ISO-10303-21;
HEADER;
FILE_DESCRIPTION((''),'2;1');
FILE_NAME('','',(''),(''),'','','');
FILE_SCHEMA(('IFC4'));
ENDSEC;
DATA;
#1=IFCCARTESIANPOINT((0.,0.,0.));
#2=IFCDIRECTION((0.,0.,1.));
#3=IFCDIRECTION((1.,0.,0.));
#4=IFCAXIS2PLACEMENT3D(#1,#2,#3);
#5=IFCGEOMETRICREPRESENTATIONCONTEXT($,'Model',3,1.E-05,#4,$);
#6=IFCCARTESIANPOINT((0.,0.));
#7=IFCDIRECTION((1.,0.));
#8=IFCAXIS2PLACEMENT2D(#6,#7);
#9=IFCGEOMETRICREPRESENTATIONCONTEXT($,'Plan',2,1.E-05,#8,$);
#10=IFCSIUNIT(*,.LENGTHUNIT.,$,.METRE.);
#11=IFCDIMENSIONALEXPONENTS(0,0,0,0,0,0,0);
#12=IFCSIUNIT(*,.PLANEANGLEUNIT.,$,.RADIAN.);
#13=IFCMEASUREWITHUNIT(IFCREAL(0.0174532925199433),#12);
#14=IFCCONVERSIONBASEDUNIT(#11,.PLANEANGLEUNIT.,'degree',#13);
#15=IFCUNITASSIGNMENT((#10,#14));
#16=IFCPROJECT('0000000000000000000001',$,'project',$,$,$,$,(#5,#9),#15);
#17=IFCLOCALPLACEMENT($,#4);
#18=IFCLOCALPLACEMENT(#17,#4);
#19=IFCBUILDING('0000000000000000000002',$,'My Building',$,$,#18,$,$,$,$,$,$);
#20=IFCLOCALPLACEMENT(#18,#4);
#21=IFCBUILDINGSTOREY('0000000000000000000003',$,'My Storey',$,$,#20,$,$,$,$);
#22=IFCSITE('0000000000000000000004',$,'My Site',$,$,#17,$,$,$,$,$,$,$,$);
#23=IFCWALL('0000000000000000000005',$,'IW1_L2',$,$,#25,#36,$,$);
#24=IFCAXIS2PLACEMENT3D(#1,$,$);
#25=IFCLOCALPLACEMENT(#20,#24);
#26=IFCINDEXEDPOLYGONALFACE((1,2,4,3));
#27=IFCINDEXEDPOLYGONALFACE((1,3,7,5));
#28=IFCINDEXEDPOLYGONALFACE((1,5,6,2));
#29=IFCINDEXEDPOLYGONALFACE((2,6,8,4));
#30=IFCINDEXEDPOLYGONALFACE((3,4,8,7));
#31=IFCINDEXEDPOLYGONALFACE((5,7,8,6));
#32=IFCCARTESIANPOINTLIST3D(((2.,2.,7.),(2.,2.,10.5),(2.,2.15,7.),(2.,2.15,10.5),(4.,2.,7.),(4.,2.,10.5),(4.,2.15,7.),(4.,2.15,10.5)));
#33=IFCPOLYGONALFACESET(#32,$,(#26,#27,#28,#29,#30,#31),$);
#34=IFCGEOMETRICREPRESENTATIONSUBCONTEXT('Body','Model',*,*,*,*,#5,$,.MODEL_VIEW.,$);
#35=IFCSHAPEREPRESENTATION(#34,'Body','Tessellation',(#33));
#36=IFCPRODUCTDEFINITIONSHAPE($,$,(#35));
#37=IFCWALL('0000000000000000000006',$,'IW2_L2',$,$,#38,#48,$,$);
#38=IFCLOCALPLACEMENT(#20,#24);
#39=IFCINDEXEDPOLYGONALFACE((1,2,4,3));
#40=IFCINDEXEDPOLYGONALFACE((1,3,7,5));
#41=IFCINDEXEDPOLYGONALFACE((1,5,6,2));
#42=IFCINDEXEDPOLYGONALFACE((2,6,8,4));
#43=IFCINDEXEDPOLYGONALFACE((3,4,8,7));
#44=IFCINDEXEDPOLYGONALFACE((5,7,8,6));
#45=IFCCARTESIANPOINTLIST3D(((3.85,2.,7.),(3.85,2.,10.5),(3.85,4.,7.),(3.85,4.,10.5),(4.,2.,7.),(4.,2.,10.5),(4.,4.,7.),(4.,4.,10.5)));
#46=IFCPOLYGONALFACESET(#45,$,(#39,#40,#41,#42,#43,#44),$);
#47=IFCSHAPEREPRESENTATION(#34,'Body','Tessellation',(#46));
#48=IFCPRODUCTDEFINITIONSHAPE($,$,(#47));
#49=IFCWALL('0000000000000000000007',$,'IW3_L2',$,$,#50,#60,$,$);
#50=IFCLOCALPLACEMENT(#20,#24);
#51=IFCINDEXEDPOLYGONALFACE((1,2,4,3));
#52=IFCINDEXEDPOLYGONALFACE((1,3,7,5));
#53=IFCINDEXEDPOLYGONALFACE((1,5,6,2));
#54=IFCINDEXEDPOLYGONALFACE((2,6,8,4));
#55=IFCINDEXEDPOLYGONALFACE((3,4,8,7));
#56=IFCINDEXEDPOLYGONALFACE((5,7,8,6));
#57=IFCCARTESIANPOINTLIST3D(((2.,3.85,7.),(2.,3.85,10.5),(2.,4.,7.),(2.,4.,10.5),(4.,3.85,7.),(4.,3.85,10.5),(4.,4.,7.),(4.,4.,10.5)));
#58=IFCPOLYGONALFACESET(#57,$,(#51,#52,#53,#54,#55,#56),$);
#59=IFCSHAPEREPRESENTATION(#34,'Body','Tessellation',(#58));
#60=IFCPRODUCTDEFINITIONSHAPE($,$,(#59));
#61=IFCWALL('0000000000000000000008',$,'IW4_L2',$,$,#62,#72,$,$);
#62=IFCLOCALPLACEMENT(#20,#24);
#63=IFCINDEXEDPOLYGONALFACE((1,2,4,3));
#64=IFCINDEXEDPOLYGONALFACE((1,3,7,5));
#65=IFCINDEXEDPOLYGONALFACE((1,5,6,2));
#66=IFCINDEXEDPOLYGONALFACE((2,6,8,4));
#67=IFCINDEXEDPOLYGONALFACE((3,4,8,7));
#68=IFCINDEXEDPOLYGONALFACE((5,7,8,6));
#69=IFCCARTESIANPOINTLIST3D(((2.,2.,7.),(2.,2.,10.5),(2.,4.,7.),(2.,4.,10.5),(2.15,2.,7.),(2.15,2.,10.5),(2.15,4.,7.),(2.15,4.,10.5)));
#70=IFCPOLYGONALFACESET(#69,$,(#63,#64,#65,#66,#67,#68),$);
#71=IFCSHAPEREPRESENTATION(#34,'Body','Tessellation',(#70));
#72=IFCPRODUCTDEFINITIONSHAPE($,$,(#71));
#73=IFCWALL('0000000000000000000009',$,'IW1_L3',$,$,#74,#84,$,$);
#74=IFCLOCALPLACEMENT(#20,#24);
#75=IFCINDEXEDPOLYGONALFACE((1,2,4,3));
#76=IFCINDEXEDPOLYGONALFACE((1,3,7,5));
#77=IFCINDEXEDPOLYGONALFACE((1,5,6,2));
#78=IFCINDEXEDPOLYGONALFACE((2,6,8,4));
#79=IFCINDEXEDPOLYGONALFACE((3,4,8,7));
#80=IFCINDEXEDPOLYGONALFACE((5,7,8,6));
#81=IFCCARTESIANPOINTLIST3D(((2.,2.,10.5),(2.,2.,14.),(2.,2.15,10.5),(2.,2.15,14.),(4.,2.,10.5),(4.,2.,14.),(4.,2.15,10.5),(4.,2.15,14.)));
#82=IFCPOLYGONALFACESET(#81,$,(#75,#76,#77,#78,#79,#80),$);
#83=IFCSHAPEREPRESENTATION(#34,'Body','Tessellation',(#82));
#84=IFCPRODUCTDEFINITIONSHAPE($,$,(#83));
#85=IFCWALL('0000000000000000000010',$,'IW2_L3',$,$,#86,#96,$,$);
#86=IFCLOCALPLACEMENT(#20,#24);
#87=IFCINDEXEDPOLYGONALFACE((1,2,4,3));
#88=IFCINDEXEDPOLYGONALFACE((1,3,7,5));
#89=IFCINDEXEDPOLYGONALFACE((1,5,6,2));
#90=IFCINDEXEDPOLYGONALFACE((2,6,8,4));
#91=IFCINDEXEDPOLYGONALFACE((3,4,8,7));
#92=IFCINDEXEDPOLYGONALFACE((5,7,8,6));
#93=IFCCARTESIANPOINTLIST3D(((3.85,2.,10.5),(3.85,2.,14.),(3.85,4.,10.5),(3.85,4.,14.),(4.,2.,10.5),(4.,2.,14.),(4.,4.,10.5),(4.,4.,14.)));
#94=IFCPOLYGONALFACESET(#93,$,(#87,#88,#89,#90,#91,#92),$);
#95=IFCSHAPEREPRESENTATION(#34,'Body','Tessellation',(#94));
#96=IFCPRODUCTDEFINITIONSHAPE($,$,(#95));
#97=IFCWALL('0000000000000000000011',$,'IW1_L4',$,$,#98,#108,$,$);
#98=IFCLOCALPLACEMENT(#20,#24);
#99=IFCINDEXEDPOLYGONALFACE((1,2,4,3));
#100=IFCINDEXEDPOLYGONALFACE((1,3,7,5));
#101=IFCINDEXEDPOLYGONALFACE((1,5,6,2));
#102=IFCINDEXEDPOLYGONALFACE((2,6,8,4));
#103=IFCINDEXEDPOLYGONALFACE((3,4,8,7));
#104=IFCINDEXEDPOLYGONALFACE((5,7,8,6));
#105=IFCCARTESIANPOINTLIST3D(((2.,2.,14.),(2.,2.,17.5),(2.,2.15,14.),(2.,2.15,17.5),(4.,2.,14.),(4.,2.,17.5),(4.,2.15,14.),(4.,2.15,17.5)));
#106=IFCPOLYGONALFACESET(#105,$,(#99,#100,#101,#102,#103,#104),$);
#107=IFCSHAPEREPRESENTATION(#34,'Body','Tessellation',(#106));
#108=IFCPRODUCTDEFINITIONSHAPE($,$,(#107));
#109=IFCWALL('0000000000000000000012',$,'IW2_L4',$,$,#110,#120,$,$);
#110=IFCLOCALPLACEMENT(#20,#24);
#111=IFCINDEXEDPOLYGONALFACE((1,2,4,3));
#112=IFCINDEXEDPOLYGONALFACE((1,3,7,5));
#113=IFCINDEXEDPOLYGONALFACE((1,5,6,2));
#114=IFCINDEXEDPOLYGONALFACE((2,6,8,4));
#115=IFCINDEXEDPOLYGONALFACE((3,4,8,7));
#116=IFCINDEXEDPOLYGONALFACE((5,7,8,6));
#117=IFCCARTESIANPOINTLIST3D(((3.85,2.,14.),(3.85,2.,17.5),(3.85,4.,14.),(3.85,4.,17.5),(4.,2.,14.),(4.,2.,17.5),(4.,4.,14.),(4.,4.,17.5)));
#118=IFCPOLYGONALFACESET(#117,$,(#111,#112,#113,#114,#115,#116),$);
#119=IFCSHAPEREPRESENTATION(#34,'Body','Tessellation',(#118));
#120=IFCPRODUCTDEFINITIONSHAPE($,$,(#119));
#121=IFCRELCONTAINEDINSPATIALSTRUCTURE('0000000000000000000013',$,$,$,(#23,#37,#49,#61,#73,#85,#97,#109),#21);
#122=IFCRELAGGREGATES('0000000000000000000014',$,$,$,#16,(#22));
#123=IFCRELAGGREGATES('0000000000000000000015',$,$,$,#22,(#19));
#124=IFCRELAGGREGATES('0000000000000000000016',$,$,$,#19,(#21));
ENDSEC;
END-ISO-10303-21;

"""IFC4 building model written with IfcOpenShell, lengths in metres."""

from ifc_helpers import new_model, entity, si_unit, converted_unit, frame, origin_with_axes, origin_2d_with_axis, place, context, subcontext, project, spatial, indexed_curve, outline, extrude, element, save


model = new_model("IFC4")

# Units and contexts
model_context = context("Model", 3, precision=1e-05, world=origin_with_axes())
plan_context = context("Plan", 2, precision=1e-05, world=origin_2d_with_axis())
body_context = subcontext(model_context, "Body", "Model", "MODEL_VIEW")
ifc_project = project(units=[si_unit("LENGTHUNIT", "METRE"), converted_unit("PLANEANGLEUNIT", "degree", entity("IfcReal", 0.0174532925199433), si_unit("PLANEANGLEUNIT", "RADIAN"), dimensions=[0, 0, 0, 0, 0, 0, 0])], contexts=[model_context, plan_context])

# Site, building, storey
site_placement = place(None, origin_with_axes())
site = spatial("IfcSite", under=ifc_project, at=site_placement, Name="My Site")
building_placement = place(site_placement, origin_with_axes())
building = spatial("IfcBuilding", under=site, at=building_placement, Name="My Building")
storey_placement = place(building_placement, origin_with_axes())
storey = spatial("IfcBuildingStorey", under=building, at=storey_placement, Name="My Storey")

# Walls
for number, where, z_axis, x_axis, name in (
    (1, (2.0, 2.0, 7.0), (0.0, 0.0, 1.0), (1.0, 0.0, 0.0), "IW1_L2"),
    (2, (4.0, 2.0, 7.0), (0.0, 0.0, 1.0), (0.0, 1.0, 0.0), "IW2_L2"),
    (3, (4.0, 4.0, 7.0), (0.0, 0.0, 1.0), (-1.0, 0.0, 0.0), "IW3_L2"),
    (4, (2.0, 4.0, 7.0), (0.0, 0.0, 1.0), (0.0, -1.0, 0.0), "IW4_L2"),
):
    element("IfcWall", number, at=place(storey_placement, frame(where, z_axis=z_axis, x_axis=x_axis)), inside=storey, Name=name, context=body_context, shape_type="SweptSolid", body=[
        extrude(outline(indexed_curve([(0.0, 0.0), (0.0, 0.15), (2.0, 0.15), (2.0, 0.0), (0.0, 0.0)], self_intersect=False)), origin_with_axes(), (0.0, 0.0, 1.0), 3.5),
    ])
for number, where, z_axis, x_axis, name in (
    (5, (2.0, 2.0, 10.5), (0.0, 0.0, 1.0), (1.0, 0.0, 0.0), "IW1_L3"),
    (6, (4.0, 2.0, 10.5), (0.0, 0.0, 1.0), (0.0, 1.0, 0.0), "IW2_L3"),
):
    element("IfcWall", number, at=place(storey_placement, frame(where, z_axis=z_axis, x_axis=x_axis)), inside=storey, Name=name, context=body_context, shape_type="SweptSolid", body=[
        extrude(outline(indexed_curve([(0.0, 0.0), (0.0, 0.15), (2.0, 0.15), (2.0, 0.0), (0.0, 0.0)], self_intersect=False)), origin_with_axes(), (0.0, 0.0, 1.0), 3.5),
    ])
for number, where, z_axis, x_axis, name in (
    (7, (2.0, 2.0, 14.0), (0.0, 0.0, 1.0), (1.0, 0.0, 0.0), "IW1_L4"),
    (8, (4.0, 2.0, 14.0), (0.0, 0.0, 1.0), (0.0, 1.0, 0.0), "IW2_L4"),
):
    element("IfcWall", number, at=place(storey_placement, frame(where, z_axis=z_axis, x_axis=x_axis)), inside=storey, Name=name, context=body_context, shape_type="SweptSolid", body=[
        extrude(outline(indexed_curve([(0.0, 0.0), (0.0, 0.15), (2.0, 0.15), (2.0, 0.0), (0.0, 0.0)], self_intersect=False)), origin_with_axes(), (0.0, 0.0, 1.0), 3.5),
    ])

save(model, "model.ifc")
